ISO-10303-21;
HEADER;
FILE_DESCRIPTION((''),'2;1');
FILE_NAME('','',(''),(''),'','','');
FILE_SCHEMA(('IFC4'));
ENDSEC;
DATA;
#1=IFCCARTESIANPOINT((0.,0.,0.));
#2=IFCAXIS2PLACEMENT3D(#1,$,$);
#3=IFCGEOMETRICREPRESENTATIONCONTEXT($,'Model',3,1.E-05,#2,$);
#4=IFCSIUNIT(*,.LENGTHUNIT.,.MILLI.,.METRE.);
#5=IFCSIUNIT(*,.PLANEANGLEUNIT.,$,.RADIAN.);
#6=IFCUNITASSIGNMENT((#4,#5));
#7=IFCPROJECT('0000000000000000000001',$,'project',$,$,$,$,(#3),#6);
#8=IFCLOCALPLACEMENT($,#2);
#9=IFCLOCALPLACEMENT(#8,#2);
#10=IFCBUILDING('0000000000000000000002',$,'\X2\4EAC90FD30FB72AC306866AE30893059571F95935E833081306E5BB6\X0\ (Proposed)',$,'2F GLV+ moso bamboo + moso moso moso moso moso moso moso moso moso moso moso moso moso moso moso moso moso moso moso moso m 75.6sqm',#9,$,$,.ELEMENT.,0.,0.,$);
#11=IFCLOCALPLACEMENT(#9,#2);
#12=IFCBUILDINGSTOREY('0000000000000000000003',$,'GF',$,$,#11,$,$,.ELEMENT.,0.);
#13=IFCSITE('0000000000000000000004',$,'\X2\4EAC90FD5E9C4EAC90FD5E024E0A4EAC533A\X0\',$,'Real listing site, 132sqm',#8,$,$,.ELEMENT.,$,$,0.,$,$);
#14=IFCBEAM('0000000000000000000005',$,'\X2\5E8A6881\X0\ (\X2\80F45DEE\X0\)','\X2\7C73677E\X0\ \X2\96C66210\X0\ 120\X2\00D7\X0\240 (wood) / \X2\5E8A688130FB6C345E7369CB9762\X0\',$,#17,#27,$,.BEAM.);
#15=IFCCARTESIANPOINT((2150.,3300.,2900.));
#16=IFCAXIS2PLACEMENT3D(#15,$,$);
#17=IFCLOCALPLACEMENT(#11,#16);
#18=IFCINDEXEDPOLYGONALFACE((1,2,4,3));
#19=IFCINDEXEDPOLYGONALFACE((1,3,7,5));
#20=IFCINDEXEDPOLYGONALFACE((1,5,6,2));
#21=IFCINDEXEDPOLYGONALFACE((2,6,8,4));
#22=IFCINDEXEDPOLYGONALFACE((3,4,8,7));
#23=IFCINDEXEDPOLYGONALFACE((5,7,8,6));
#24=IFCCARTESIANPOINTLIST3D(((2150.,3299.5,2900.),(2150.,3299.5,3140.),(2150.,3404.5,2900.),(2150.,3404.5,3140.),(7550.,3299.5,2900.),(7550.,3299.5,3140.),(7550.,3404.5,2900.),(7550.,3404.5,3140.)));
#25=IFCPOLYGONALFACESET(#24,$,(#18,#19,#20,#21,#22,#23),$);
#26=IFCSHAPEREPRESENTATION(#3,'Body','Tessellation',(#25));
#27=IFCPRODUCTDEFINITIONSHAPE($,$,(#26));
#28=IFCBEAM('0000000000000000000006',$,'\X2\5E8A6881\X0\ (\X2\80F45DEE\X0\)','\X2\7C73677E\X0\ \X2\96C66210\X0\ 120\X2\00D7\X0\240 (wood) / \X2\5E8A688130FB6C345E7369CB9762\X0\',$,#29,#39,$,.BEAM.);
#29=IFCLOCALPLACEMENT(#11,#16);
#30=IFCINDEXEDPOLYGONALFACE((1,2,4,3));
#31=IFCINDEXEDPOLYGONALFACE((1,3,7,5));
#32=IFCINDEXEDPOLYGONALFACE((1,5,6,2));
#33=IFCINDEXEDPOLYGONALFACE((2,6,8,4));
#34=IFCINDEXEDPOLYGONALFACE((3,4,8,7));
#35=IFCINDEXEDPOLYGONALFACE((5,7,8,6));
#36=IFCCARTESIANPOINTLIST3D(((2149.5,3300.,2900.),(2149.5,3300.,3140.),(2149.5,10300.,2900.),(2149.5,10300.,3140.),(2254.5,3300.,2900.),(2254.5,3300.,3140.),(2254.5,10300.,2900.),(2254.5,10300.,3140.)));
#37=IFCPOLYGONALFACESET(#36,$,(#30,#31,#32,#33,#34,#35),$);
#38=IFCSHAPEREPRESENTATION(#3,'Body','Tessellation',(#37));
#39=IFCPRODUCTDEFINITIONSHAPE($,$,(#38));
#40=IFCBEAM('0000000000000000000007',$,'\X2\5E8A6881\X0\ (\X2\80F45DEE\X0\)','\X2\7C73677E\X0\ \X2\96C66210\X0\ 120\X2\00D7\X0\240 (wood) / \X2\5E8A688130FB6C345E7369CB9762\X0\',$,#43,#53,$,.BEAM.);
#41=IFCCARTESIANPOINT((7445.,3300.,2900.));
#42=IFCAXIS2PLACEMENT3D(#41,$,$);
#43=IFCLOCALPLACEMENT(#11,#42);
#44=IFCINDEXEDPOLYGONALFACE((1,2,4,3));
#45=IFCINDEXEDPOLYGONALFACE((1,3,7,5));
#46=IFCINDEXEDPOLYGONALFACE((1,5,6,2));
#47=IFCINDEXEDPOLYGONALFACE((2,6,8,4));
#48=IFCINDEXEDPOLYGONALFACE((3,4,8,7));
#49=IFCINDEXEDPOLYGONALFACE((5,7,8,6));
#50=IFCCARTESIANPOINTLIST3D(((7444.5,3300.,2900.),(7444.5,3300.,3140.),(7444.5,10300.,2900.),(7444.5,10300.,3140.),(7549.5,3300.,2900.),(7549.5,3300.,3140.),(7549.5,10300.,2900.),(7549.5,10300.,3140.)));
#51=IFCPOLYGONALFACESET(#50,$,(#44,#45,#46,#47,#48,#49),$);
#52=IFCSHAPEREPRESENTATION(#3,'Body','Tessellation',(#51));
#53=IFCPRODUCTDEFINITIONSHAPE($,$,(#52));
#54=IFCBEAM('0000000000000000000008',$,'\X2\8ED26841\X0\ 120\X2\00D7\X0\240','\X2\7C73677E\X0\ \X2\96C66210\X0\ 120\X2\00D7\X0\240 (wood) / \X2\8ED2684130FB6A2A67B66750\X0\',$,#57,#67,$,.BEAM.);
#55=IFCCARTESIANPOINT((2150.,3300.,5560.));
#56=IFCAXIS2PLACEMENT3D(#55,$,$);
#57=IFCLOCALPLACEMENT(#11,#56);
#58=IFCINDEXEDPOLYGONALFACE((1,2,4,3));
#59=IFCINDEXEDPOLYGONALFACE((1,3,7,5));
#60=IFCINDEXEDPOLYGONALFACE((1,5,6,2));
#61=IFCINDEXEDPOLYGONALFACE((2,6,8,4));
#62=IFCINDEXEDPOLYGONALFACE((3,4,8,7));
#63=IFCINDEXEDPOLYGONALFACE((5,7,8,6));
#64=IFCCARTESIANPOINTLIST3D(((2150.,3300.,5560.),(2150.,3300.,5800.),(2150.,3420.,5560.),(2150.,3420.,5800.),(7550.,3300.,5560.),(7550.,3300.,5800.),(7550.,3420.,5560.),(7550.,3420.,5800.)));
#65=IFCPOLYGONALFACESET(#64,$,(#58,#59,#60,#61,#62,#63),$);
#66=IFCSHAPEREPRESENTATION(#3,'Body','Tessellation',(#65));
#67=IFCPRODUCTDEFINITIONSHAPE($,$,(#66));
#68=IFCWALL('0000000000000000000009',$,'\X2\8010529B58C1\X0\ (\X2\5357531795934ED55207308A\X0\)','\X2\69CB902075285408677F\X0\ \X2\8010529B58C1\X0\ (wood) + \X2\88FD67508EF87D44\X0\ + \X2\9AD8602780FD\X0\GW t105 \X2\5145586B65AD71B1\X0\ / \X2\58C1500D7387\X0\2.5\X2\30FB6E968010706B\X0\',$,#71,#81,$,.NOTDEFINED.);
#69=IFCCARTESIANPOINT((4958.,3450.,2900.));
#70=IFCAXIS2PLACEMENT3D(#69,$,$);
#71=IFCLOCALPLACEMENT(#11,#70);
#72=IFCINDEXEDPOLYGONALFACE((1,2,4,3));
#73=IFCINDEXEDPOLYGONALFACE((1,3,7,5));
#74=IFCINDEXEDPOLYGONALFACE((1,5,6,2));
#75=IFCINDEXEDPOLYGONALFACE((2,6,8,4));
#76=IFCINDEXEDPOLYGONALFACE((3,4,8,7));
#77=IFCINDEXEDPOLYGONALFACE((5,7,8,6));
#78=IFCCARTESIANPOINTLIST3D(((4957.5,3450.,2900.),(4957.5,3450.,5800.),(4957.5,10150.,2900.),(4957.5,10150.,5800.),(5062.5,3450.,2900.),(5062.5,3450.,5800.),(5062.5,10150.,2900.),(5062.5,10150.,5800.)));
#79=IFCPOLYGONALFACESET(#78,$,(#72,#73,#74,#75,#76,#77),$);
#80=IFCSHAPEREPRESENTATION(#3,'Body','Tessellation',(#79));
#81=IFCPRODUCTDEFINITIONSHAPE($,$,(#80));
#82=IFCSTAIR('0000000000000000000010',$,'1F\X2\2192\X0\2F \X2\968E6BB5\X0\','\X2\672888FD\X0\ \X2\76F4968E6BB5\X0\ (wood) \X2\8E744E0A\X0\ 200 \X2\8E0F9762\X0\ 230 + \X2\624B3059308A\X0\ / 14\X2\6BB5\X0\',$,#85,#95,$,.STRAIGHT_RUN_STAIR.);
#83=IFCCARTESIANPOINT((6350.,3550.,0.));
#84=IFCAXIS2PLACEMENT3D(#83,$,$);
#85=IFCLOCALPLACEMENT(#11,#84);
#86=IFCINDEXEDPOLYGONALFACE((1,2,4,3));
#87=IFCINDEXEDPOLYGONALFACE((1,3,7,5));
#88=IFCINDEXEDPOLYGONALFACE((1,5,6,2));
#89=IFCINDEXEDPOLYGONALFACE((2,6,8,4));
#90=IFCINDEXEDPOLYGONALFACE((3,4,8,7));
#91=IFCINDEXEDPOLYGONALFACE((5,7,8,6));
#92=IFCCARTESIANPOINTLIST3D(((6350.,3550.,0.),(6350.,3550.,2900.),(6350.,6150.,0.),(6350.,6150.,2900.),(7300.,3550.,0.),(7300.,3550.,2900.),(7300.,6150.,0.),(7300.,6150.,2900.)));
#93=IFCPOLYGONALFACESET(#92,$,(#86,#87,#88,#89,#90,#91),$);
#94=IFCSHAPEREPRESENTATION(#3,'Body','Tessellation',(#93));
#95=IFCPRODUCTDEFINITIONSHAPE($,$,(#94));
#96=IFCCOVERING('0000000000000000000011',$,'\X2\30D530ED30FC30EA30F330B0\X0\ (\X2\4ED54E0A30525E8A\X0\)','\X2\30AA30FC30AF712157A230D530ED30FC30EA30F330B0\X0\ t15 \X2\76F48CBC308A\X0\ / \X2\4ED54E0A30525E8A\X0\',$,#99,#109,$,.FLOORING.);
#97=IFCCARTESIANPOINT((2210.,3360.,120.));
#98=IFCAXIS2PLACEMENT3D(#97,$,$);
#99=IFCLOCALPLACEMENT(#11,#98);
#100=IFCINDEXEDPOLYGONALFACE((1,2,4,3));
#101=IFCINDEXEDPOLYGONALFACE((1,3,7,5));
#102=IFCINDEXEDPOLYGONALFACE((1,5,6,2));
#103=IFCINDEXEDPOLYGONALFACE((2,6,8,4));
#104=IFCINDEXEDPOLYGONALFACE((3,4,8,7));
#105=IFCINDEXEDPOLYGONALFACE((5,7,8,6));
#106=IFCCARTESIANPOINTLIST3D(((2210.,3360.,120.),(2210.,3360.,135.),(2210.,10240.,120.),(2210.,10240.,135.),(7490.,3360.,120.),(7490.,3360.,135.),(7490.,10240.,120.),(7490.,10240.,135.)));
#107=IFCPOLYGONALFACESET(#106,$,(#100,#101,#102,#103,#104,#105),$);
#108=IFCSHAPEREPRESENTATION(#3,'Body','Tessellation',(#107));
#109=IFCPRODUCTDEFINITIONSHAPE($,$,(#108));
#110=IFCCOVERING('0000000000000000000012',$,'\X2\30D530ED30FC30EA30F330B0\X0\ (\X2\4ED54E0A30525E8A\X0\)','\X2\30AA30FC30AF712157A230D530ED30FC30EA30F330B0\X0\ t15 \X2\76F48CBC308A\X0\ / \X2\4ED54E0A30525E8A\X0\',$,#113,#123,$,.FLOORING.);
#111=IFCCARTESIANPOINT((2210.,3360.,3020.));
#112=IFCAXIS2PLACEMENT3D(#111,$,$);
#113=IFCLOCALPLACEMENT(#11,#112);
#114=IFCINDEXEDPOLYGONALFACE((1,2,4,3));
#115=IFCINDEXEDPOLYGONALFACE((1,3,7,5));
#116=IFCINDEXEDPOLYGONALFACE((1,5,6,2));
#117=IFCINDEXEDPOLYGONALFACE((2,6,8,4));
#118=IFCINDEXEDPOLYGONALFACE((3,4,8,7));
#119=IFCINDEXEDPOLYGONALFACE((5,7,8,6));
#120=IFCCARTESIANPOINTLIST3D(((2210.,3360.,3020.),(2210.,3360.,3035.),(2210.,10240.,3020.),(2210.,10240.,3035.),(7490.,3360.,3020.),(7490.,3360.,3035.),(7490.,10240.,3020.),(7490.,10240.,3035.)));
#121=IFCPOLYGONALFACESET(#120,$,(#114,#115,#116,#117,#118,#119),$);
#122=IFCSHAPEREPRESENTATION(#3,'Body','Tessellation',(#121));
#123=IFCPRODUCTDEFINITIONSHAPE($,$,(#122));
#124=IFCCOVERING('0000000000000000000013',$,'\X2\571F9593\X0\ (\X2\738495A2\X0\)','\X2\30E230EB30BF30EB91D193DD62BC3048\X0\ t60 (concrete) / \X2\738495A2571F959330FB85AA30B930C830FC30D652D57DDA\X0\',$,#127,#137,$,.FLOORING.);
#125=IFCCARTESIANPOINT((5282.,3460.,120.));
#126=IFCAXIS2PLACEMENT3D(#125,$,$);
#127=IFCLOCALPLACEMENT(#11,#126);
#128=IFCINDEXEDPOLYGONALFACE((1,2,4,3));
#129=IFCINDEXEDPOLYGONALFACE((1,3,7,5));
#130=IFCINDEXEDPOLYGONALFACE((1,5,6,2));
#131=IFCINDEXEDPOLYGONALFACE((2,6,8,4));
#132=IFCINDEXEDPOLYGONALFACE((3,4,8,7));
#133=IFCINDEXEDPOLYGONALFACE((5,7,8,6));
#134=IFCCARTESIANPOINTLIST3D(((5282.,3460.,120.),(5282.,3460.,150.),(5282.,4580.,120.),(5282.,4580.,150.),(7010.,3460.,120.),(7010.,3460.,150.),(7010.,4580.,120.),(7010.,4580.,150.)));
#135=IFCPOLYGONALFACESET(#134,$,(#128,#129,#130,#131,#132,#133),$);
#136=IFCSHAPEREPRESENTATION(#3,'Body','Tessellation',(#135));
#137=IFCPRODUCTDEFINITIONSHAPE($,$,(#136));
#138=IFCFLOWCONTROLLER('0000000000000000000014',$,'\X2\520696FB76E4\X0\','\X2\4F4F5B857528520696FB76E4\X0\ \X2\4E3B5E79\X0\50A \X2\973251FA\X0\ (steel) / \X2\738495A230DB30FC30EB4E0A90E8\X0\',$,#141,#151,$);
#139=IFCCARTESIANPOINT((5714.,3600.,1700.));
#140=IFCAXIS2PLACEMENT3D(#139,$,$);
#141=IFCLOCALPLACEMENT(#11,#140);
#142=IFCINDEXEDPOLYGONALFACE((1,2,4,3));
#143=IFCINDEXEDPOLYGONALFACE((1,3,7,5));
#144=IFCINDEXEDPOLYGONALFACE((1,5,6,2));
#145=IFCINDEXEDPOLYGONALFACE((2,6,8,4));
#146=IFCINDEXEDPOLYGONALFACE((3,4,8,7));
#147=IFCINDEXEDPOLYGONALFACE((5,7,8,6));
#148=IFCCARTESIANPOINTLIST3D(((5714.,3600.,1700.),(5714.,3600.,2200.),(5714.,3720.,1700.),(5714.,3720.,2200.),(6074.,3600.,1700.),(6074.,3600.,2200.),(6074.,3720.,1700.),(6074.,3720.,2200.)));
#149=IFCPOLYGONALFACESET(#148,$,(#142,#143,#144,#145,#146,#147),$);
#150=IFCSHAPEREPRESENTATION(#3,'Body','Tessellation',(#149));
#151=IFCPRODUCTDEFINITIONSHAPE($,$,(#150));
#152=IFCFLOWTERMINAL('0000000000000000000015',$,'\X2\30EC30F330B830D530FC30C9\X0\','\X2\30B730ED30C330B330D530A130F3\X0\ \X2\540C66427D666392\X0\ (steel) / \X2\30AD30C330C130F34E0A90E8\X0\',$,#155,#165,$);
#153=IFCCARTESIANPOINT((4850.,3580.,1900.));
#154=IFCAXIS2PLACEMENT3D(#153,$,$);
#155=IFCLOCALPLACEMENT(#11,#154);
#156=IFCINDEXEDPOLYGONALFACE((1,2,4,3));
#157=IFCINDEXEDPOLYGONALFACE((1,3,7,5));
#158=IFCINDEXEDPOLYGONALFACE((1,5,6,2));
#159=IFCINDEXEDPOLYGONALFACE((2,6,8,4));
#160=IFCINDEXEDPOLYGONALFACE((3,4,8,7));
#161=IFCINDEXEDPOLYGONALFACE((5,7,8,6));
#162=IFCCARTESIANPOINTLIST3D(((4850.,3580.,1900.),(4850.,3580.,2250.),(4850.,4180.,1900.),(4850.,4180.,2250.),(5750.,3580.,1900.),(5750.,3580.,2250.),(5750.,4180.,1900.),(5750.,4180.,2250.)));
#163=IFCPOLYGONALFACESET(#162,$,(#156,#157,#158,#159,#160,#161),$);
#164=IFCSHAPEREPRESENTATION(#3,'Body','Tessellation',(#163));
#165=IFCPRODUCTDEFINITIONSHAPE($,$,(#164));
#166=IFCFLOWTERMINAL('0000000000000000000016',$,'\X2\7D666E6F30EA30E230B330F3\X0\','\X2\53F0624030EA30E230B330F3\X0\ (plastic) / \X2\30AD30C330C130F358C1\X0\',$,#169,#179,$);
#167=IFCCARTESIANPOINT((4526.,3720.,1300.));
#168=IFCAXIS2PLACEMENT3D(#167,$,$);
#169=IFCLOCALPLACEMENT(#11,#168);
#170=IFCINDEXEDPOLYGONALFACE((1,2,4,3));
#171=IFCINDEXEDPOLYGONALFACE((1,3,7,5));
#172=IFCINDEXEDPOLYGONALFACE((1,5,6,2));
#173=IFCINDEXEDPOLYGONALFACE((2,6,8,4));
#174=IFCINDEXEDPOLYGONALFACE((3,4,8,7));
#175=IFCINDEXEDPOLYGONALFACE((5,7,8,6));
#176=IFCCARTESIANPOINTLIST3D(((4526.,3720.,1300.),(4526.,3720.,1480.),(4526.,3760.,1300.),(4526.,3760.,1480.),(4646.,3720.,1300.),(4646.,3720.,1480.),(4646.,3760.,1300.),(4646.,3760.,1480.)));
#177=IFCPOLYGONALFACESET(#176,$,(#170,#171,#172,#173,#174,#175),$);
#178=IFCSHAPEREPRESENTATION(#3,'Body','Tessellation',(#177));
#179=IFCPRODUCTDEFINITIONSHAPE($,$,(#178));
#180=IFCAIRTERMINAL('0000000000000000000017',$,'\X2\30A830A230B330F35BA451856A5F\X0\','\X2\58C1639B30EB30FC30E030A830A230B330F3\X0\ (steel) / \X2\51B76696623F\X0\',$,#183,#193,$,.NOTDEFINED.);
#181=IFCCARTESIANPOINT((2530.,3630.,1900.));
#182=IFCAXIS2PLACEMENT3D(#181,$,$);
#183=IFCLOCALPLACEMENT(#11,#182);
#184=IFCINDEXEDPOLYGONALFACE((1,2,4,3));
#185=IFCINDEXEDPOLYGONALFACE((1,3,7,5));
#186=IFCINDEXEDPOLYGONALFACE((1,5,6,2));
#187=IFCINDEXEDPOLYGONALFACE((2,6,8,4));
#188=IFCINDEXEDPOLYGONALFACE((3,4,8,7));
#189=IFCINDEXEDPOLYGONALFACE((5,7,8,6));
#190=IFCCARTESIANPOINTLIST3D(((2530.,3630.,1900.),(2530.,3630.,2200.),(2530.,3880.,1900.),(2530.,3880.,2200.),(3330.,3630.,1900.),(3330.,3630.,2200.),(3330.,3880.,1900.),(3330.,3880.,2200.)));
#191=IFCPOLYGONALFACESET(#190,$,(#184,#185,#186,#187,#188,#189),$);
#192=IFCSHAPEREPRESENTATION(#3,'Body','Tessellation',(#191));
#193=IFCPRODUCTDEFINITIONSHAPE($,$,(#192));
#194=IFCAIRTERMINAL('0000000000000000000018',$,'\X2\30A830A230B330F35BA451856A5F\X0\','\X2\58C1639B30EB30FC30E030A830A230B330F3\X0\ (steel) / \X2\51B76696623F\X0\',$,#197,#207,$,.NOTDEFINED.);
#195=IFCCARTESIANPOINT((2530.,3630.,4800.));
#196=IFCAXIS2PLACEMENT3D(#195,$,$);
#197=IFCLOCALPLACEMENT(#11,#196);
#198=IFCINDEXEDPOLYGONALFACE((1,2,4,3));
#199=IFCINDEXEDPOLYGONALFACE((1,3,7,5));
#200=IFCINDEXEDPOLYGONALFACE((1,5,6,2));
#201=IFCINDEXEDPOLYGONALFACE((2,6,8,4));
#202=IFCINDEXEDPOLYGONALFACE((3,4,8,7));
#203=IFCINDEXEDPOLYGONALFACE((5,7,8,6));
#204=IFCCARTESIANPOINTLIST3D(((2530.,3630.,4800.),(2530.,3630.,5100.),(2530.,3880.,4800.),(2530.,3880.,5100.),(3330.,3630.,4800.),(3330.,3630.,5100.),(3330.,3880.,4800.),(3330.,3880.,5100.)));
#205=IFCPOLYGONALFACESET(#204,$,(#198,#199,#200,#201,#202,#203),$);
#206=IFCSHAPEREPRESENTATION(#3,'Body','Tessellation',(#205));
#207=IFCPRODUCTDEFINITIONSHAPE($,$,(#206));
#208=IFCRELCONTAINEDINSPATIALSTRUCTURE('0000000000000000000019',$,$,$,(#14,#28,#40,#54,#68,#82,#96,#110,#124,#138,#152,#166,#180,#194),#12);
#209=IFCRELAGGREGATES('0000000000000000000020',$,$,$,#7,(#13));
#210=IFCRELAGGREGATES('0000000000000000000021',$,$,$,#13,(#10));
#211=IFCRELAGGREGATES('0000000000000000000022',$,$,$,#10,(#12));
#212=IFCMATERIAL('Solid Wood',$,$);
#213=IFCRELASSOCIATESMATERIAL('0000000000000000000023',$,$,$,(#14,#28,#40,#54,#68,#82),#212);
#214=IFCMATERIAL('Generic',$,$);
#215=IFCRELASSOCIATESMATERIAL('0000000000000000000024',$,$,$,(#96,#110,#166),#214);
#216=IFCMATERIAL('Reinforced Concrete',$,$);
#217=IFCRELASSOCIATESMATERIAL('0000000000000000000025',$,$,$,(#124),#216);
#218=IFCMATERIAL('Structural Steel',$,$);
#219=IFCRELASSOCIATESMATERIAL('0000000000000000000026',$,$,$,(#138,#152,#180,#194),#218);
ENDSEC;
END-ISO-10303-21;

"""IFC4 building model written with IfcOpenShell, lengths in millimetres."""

from ifc_helpers import new_model, si_unit, frame, frame_2d, origin, place, context, project, spatial, rectangle, extrude, material, element, save


model = new_model("IFC4")

# Units and contexts
model_context = context("Model", 3, precision=1e-05, world=origin())
ifc_project = project(units=[si_unit("LENGTHUNIT", "METRE", prefix="MILLI"), si_unit("PLANEANGLEUNIT", "RADIAN")], contexts=[model_context])

# Site, building, storey
site_placement = place(None, origin())
site = spatial("IfcSite", under=ifc_project, at=site_placement, Name="京都府京都市上京区", ObjectType="Real listing site, 132sqm", CompositionType="ELEMENT", RefElevation=0.0)
building_placement = place(site_placement, origin())
building = spatial("IfcBuilding", under=site, at=building_placement, Name="京都・犬と暮らす土間広めの家 (Proposed)", ObjectType="2F GLV+ moso bamboo + moso moso moso moso moso moso moso moso moso moso moso moso moso moso moso moso moso moso moso moso m 75.6sqm", CompositionType="ELEMENT", ElevationOfRefHeight=0.0, ElevationOfTerrain=0.0)
storey_placement = place(building_placement, origin())
storey = spatial("IfcBuildingStorey", under=building, at=storey_placement, Name="GF", CompositionType="ELEMENT", Elevation=0.0)

# Shared definitions
ifc_material_1 = material(Name="Solid Wood")

# Beams
beam_1_placement = place(storey_placement, frame((2150.0, 3300.0, 2900.0)))
element("IfcBeam", 1, at=beam_1_placement, inside=storey, material=ifc_material_1, Name="床梁 (胴差)", Description="米松 集成 120×240 (wood) / 床梁・水平構面", PredefinedType="BEAM", context=model_context, shape_type="SweptSolid", body=[
    extrude(rectangle(XDim=5400.0, YDim=105.0, at=frame_2d((2700.0, 52.0))), frame((2150.0, 3300.0, 2900.0)), (0.0, 0.0, 1.0), 240.0),
])
beam_2_placement = place(storey_placement, frame((2150.0, 3300.0, 2900.0)))
element("IfcBeam", 2, at=beam_2_placement, inside=storey, material=ifc_material_1, Name="床梁 (胴差)", Description="米松 集成 120×240 (wood) / 床梁・水平構面", PredefinedType="BEAM", context=model_context, shape_type="SweptSolid", body=[
    extrude(rectangle(XDim=105.0, YDim=7000.0, at=frame_2d((52.0, 3500.0))), frame((2150.0, 3300.0, 2900.0)), (0.0, 0.0, 1.0), 240.0),
])
beam_3_placement = place(storey_placement, frame((7445.0, 3300.0, 2900.0)))
element("IfcBeam", 3, at=beam_3_placement, inside=storey, material=ifc_material_1, Name="床梁 (胴差)", Description="米松 集成 120×240 (wood) / 床梁・水平構面", PredefinedType="BEAM", context=model_context, shape_type="SweptSolid", body=[
    extrude(rectangle(XDim=105.0, YDim=7000.0, at=frame_2d((52.0, 3500.0))), frame((7445.0, 3300.0, 2900.0)), (0.0, 0.0, 1.0), 240.0),
])
beam_4_placement = place(storey_placement, frame((2150.0, 3300.0, 5560.0)))
element("IfcBeam", 4, at=beam_4_placement, inside=storey, material=ifc_material_1, Name="軒桁 120×240", Description="米松 集成 120×240 (wood) / 軒桁・横架材", PredefinedType="BEAM", context=model_context, shape_type="SweptSolid", body=[
    extrude(rectangle(XDim=5400.0, YDim=120.0, at=frame_2d((2700.0, 60.0))), frame((2150.0, 3300.0, 5560.0)), (0.0, 0.0, 1.0), 240.0),
])

# Wall
wall_1_placement = place(storey_placement, frame((4958.0, 3450.0, 2900.0)))
element("IfcWall", 5, at=wall_1_placement, inside=storey, material=ifc_material_1, Name="耐力壁 (南北間仕切り)", Description="構造用合板 耐力壁 (wood) + 製材軸組 + 高性能GW t105 充填断熱 / 壁倍率2.5・準耐火", PredefinedType="NOTDEFINED", context=model_context, shape_type="SweptSolid", body=[
    extrude(rectangle(XDim=105.0, YDim=6700.0, at=frame_2d((52.0, 3350.0))), frame((4958.0, 3450.0, 2900.0)), (0.0, 0.0, 1.0), 2900.0),
])

# Stair
stair_placement = place(storey_placement, frame((6350.0, 3550.0, 0.0)))
element("IfcStair", 6, at=stair_placement, inside=storey, material=ifc_material_1, Name="1F→2F 階段", Description="木製 直階段 (wood) 蹴上 200 踏面 230 + 手すり / 14段", PredefinedType="STRAIGHT_RUN_STAIR", context=model_context, shape_type="SweptSolid", body=[
    extrude(rectangle(XDim=950.0, YDim=2600.0, at=frame_2d((475.0, 1300.0))), frame((6350.0, 3550.0, 0.0)), (0.0, 0.0, 1.0), 2900.0),
])

# Coverings
ifc_material_2 = material(Name="Generic")
covering_1_placement = place(storey_placement, frame((2210.0, 3360.0, 120.0)))
element("IfcCovering", 7, at=covering_1_placement, inside=storey, material=ifc_material_2, Name="フローリング (仕上げ床)", Description="オーク無垢フローリング t15 直貼り / 仕上げ床", PredefinedType="FLOORING", context=model_context, shape_type="SweptSolid", body=[
    extrude(rectangle(XDim=5280.0, YDim=6880.0, at=frame_2d((2640.0, 3440.0))), frame((2210.0, 3360.0, 120.0)), (0.0, 0.0, 1.0), 15.0),
])
covering_2_placement = place(storey_placement, frame((2210.0, 3360.0, 3020.0)))
element("IfcCovering", 8, at=covering_2_placement, inside=storey, material=ifc_material_2, Name="フローリング (仕上げ床)", Description="オーク無垢フローリング t15 直貼り / 仕上げ床", PredefinedType="FLOORING", context=model_context, shape_type="SweptSolid", body=[
    extrude(rectangle(XDim=5280.0, YDim=6880.0, at=frame_2d((2640.0, 3440.0))), frame((2210.0, 3360.0, 3020.0)), (0.0, 0.0, 1.0), 15.0),
])
ifc_material_3 = material(Name="Reinforced Concrete")
covering_3_placement = place(storey_placement, frame((5282.0, 3460.0, 120.0)))
element("IfcCovering", 9, at=covering_3_placement, inside=storey, material=ifc_material_3, Name="土間 (玄関)", Description="モルタル金鏝押え t60 (concrete) / 玄関土間・薪ストーブ動線", PredefinedType="FLOORING", context=model_context, shape_type="SweptSolid", body=[
    extrude(rectangle(XDim=1728.0, YDim=1120.0, at=frame_2d((864.0, 560.0))), frame((5282.0, 3460.0, 120.0)), (0.0, 0.0, 1.0), 30.0),
])

# Flow controller
ifc_material_4 = material(Name="Structural Steel")
flow_controller_placement = place(storey_placement, frame((5714.0, 3600.0, 1700.0)))
element("IfcFlowController", 10, at=flow_controller_placement, inside=storey, material=ifc_material_4, Name="分電盤", Description="住宅用分電盤 主幹50A 露出 (steel) / 玄関ホール上部", context=model_context, shape_type="SweptSolid", body=[
    extrude(rectangle(XDim=360.0, YDim=120.0, at=frame_2d((180.0, 60.0))), frame((5714.0, 3600.0, 1700.0)), (0.0, 0.0, 1.0), 500.0),
])

# Flow terminals
flow_terminal_1_placement = place(storey_placement, frame((4850.0, 3580.0, 1900.0)))
element("IfcFlowTerminal", 11, at=flow_terminal_1_placement, inside=storey, material=ifc_material_4, Name="レンジフード", Description="シロッコファン 同時給排 (steel) / キッチン上部", context=model_context, shape_type="SweptSolid", body=[
    extrude(rectangle(XDim=900.0, YDim=600.0, at=frame_2d((450.0, 300.0))), frame((4850.0, 3580.0, 1900.0)), (0.0, 0.0, 1.0), 350.0),
])
flow_terminal_2_placement = place(storey_placement, frame((4526.0, 3720.0, 1300.0)))
element("IfcFlowTerminal", 12, at=flow_terminal_2_placement, inside=storey, material=ifc_material_2, Name="給湯リモコン", Description="台所リモコン (plastic) / キッチン壁", context=model_context, shape_type="SweptSolid", body=[
    extrude(rectangle(XDim=120.0, YDim=40.0, at=frame_2d((60.0, 20.0))), frame((4526.0, 3720.0, 1300.0)), (0.0, 0.0, 1.0), 180.0),
])

# Air terminals
air_terminal_1_placement = place(storey_placement, frame((2530.0, 3630.0, 1900.0)))
element("IfcAirTerminal", 13, at=air_terminal_1_placement, inside=storey, material=ifc_material_4, Name="エアコン室内機", Description="壁掛ルームエアコン (steel) / 冷暖房", PredefinedType="NOTDEFINED", context=model_context, shape_type="SweptSolid", body=[
    extrude(rectangle(XDim=800.0, YDim=250.0, at=frame_2d((400.0, 125.0))), frame((2530.0, 3630.0, 1900.0)), (0.0, 0.0, 1.0), 300.0),
])
air_terminal_2_placement = place(storey_placement, frame((2530.0, 3630.0, 4800.0)))
element("IfcAirTerminal", 14, at=air_terminal_2_placement, inside=storey, material=ifc_material_4, Name="エアコン室内機", Description="壁掛ルームエアコン (steel) / 冷暖房", PredefinedType="NOTDEFINED", context=model_context, shape_type="SweptSolid", body=[
    extrude(rectangle(XDim=800.0, YDim=250.0, at=frame_2d((400.0, 125.0))), frame((2530.0, 3630.0, 4800.0)), (0.0, 0.0, 1.0), 300.0),
])

save(model, "model.ifc")
